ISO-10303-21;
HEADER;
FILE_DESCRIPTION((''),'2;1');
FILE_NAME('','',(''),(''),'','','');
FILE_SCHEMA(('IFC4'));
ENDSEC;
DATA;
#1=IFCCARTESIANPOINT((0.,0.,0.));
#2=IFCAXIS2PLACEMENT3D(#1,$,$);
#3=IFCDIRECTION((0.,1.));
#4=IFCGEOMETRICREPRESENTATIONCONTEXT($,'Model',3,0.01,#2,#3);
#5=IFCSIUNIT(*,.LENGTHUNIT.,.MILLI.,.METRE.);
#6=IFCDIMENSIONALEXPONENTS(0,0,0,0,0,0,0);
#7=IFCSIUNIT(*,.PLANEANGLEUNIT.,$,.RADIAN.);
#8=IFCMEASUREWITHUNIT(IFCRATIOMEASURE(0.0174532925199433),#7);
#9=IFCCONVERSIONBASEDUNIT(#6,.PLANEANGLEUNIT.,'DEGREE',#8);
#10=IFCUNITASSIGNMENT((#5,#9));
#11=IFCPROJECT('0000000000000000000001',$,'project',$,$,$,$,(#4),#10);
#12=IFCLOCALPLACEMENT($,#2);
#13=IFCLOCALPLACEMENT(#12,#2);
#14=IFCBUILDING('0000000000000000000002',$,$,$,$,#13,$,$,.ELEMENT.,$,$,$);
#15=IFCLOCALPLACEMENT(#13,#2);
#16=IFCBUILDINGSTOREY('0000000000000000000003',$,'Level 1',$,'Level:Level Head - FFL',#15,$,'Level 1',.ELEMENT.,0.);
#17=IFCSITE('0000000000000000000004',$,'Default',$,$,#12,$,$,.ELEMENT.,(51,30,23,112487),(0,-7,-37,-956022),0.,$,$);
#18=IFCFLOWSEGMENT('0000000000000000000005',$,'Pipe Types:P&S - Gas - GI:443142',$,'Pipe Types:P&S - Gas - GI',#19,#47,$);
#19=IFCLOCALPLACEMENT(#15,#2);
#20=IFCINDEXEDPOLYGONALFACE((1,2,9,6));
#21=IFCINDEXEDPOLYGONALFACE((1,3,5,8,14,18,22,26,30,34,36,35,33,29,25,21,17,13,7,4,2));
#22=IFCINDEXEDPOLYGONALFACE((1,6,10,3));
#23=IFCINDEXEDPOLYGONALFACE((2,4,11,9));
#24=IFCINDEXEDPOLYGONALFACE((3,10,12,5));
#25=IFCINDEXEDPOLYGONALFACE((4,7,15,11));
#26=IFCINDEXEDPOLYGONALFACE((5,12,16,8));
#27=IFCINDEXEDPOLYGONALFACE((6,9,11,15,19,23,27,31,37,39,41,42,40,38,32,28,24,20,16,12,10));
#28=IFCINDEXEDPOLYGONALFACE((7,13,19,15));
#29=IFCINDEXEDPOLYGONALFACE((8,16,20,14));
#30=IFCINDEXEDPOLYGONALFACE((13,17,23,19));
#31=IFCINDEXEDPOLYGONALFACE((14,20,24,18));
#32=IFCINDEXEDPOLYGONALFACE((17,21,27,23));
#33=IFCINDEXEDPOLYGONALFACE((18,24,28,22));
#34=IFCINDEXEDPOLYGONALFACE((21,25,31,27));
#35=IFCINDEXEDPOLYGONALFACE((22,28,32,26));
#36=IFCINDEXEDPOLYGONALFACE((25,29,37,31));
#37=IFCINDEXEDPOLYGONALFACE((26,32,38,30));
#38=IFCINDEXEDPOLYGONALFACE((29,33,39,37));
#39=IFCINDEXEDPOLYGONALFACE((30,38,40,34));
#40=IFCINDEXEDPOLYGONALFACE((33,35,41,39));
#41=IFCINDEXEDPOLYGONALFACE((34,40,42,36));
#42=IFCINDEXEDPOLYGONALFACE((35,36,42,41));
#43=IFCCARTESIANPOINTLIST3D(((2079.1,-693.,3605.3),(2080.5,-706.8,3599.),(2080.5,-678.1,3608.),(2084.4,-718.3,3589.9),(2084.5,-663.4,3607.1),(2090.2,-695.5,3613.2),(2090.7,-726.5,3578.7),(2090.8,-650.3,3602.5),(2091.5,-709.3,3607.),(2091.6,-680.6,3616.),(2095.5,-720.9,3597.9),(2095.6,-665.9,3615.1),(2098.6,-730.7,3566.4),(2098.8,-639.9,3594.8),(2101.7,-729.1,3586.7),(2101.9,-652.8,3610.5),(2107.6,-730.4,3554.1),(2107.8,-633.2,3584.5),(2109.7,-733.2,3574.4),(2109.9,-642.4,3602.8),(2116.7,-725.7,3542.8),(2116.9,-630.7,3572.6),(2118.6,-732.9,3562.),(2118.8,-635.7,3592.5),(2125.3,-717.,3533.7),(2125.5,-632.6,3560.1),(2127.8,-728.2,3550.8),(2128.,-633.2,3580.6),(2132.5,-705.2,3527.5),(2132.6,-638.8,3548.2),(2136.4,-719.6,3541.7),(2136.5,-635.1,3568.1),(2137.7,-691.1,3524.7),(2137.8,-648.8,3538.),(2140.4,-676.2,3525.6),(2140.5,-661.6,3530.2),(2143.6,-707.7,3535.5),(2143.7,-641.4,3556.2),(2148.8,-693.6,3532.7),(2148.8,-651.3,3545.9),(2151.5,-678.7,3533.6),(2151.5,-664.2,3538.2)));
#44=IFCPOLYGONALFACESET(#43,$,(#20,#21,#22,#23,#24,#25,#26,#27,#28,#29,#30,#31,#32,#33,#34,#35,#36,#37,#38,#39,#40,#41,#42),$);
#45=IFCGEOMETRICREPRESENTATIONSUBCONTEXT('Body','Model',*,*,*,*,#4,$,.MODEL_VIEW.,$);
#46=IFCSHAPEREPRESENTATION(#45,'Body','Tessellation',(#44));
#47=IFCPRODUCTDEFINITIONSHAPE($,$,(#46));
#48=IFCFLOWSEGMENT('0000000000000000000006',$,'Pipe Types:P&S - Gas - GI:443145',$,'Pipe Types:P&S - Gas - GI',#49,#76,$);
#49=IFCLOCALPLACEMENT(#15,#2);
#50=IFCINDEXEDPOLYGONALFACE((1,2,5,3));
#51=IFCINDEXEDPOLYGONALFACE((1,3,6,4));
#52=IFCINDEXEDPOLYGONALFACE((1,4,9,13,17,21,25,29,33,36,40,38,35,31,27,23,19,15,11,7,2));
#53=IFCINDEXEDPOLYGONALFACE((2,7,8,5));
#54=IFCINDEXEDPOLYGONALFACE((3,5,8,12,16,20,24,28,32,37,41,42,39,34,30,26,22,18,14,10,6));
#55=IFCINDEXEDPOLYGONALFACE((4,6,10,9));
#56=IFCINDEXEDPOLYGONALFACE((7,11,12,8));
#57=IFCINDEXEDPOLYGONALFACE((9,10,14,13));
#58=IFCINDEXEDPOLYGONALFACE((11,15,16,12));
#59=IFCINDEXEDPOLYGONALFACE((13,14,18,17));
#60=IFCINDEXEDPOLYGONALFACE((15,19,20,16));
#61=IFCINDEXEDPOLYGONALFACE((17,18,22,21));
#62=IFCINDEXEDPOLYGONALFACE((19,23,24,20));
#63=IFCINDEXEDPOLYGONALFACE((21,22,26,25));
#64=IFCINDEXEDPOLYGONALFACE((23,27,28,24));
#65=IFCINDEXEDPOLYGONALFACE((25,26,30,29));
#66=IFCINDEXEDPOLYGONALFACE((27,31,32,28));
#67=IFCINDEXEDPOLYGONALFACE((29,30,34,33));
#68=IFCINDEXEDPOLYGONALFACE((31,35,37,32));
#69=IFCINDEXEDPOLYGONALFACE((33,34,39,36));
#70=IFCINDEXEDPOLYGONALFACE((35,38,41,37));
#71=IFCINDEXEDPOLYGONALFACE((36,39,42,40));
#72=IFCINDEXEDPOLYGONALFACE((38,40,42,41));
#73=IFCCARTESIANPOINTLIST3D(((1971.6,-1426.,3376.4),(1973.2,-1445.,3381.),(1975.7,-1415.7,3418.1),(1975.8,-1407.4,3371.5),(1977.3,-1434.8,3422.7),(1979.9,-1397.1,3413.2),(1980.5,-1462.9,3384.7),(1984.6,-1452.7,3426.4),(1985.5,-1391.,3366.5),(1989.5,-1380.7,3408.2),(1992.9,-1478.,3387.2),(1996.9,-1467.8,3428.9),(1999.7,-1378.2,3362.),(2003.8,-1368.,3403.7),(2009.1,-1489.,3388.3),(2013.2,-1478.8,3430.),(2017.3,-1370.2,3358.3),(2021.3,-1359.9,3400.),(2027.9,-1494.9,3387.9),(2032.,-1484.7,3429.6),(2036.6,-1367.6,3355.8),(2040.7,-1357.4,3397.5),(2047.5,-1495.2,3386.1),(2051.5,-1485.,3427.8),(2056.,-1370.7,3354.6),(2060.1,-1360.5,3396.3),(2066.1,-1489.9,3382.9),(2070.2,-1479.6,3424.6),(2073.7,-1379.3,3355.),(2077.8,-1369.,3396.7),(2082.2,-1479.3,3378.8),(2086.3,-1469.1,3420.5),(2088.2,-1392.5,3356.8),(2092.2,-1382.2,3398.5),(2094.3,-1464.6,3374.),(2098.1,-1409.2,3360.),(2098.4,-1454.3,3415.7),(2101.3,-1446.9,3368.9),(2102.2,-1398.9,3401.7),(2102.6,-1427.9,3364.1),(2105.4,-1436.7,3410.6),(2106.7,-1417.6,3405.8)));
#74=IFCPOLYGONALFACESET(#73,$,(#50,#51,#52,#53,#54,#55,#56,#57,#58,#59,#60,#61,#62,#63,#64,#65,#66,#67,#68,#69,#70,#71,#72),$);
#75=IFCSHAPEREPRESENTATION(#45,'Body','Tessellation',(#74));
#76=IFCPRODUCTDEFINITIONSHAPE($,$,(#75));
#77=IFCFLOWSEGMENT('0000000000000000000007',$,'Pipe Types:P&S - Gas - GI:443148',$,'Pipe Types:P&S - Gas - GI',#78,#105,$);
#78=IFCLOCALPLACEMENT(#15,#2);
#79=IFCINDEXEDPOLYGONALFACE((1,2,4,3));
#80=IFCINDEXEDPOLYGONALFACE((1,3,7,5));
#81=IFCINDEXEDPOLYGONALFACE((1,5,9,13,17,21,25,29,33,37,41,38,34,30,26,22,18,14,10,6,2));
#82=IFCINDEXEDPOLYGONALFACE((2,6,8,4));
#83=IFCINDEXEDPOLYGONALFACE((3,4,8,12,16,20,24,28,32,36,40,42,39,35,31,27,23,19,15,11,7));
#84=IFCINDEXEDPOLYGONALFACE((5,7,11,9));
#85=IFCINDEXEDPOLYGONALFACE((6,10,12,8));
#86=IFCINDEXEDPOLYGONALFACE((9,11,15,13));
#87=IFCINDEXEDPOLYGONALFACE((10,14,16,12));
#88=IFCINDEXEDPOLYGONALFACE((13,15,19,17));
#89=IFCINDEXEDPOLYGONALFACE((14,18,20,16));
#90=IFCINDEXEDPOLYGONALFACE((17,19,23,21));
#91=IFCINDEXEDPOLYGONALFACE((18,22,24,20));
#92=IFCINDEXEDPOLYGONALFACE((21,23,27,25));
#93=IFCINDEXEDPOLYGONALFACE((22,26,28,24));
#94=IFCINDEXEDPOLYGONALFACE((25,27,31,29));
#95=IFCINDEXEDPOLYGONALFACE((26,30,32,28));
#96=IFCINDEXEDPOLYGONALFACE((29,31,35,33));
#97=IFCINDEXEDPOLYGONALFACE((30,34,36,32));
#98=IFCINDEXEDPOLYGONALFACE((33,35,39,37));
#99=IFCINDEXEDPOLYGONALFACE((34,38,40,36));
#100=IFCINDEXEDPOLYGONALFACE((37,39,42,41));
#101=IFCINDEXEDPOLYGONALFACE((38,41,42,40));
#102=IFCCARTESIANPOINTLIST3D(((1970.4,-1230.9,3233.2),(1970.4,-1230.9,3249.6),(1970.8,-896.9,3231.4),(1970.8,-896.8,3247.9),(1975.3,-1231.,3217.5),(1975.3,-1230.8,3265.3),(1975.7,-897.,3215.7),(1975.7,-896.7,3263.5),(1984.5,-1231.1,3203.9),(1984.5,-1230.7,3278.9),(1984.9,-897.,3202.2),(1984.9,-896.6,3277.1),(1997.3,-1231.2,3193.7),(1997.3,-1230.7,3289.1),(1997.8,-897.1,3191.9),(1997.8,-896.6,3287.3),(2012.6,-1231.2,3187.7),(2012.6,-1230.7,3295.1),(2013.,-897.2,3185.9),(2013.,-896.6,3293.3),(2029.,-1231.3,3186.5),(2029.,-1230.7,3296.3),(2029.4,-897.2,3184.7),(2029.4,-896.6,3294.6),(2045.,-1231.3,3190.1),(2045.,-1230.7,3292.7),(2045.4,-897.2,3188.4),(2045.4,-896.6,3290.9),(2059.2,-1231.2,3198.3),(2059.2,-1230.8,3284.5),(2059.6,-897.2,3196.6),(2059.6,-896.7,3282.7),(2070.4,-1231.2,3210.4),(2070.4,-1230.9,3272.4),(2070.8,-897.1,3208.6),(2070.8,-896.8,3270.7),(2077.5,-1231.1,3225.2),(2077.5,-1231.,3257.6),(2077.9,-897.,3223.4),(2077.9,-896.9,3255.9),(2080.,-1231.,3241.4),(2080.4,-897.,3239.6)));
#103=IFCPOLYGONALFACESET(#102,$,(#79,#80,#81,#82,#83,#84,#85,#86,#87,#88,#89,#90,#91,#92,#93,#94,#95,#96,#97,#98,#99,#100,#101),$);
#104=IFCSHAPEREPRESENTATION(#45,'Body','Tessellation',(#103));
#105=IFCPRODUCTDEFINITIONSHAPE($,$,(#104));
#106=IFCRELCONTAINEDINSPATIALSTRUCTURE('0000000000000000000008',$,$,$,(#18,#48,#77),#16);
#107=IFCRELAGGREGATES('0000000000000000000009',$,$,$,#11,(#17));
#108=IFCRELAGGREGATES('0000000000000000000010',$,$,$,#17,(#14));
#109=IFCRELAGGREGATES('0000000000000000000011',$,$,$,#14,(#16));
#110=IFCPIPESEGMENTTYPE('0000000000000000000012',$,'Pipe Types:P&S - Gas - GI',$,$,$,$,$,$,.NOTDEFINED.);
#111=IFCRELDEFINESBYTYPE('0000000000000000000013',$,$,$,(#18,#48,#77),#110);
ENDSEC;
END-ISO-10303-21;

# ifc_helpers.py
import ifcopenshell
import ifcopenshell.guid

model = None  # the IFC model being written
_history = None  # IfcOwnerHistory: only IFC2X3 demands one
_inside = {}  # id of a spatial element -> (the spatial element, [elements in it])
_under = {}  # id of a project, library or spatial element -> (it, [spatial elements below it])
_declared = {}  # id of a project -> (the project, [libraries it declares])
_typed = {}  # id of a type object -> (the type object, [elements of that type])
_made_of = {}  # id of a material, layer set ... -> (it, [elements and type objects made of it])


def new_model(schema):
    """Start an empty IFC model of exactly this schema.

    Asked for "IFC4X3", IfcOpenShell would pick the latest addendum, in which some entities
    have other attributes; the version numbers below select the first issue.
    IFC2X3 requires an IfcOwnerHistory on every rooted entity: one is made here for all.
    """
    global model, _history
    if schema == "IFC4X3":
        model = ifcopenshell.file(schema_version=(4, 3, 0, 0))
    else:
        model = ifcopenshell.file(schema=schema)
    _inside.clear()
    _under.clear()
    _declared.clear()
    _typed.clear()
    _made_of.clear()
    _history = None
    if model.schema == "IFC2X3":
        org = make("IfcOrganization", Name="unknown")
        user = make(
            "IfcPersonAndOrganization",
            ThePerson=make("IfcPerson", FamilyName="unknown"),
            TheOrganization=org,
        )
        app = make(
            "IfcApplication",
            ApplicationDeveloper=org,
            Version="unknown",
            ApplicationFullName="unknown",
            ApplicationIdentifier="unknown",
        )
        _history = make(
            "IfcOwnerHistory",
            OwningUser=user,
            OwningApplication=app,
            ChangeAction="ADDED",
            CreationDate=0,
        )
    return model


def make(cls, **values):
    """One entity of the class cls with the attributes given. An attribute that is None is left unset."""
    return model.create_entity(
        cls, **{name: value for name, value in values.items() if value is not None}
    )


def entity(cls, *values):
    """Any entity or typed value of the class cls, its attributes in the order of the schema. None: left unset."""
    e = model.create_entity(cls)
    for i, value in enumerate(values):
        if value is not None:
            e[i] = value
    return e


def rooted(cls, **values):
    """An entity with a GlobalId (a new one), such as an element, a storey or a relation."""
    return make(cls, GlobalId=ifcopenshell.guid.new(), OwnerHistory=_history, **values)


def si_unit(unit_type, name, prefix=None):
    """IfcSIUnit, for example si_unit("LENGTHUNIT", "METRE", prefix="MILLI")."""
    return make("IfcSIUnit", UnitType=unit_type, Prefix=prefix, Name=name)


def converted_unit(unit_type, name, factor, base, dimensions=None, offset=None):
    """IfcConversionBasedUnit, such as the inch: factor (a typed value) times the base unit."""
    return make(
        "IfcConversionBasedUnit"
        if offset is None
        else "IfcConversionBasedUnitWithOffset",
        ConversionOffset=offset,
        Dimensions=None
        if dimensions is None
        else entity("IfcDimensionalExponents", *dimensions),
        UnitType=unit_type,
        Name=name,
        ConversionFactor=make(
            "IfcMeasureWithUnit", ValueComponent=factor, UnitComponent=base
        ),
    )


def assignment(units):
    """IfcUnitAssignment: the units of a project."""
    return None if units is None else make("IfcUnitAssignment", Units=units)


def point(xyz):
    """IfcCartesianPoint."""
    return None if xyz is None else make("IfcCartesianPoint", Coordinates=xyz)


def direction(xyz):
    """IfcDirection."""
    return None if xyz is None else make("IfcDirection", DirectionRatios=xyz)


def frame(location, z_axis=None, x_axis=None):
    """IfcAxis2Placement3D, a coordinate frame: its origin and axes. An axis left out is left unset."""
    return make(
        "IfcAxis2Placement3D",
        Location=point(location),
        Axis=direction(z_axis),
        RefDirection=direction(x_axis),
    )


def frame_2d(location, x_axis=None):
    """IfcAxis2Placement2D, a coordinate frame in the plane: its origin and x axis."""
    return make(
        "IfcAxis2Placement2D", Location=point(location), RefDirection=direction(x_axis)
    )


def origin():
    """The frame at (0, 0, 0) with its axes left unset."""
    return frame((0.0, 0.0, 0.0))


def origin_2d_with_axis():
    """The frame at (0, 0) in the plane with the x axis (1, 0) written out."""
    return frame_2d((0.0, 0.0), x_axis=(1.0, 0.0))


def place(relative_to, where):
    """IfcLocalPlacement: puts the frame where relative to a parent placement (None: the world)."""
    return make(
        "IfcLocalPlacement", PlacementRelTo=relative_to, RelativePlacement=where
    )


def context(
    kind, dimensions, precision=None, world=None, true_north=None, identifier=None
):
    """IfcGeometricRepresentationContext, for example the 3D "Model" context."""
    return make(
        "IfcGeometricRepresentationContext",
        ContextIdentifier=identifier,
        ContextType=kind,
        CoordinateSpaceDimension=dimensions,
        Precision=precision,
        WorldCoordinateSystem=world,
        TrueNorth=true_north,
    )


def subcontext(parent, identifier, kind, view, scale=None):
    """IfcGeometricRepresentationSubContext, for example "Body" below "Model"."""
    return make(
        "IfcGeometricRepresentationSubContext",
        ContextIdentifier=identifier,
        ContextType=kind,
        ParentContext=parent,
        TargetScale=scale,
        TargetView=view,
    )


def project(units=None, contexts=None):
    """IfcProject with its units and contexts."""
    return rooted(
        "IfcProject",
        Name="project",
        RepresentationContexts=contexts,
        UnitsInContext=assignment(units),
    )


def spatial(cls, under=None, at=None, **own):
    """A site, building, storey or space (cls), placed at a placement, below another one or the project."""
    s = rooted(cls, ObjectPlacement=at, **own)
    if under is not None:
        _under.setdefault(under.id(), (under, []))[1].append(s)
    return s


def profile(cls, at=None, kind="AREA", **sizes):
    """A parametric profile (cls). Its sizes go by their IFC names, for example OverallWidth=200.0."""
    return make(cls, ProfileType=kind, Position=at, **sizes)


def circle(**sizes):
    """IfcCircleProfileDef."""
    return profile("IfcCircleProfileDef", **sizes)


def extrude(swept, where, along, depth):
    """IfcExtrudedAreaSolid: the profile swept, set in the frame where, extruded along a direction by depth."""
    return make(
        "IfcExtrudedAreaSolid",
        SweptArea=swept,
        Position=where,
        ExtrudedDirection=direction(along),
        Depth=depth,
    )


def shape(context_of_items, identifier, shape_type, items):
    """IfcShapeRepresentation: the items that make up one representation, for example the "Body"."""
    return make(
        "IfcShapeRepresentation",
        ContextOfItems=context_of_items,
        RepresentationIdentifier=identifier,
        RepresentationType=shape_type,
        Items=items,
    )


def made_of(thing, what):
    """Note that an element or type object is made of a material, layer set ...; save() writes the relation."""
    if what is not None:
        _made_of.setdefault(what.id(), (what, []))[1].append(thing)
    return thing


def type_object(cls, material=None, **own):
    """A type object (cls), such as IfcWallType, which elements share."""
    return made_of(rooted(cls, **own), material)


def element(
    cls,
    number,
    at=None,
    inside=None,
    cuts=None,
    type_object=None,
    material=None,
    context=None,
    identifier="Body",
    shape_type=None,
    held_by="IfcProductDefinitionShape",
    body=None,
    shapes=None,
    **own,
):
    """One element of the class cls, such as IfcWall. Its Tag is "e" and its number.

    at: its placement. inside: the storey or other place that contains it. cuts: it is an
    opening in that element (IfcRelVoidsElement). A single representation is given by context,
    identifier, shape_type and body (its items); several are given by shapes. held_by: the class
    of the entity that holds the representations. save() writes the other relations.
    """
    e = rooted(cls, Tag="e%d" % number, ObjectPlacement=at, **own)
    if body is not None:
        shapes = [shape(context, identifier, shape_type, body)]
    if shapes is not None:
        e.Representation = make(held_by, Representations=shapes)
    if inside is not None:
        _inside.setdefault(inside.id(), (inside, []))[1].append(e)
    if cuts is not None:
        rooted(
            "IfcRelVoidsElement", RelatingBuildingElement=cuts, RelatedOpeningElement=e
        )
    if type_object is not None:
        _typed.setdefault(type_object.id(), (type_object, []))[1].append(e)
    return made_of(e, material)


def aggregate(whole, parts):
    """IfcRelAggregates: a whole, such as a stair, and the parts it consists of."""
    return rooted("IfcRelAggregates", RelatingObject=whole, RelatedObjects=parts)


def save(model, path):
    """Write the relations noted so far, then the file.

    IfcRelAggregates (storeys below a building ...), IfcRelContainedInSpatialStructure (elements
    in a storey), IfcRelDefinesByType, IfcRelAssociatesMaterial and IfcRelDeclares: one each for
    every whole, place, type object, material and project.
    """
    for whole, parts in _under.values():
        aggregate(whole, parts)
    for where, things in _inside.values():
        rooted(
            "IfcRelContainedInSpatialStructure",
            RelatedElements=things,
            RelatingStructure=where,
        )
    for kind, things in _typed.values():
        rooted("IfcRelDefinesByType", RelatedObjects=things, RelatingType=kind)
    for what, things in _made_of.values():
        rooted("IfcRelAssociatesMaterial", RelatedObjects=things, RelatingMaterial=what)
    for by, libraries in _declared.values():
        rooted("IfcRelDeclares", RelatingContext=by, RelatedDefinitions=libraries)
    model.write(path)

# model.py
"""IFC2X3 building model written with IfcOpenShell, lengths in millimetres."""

from ifc_helpers import new_model, entity, si_unit, converted_unit, direction, frame, frame_2d, origin, origin_2d_with_axis, place, context, subcontext, project, spatial, circle, extrude, type_object, element, save


model = new_model("IFC2X3")

# Units and contexts
model_context = context("Model", 3, precision=0.01, world=origin(), true_north=direction((0.0, 1.0)))
body_context = subcontext(model_context, "Body", "Model", "MODEL_VIEW")
ifc_project = project(units=[si_unit("LENGTHUNIT", "METRE", prefix="MILLI"), converted_unit("PLANEANGLEUNIT", "DEGREE", entity("IfcRatioMeasure", 0.0174532925199433), si_unit("PLANEANGLEUNIT", "RADIAN"), dimensions=[0, 0, 0, 0, 0, 0, 0])], contexts=[model_context])

# Site, building, storey
site_placement = place(None, origin())
site = spatial("IfcSite", under=ifc_project, at=site_placement, Name="Default", CompositionType="ELEMENT", RefLatitude=(51, 30, 23, 112487), RefLongitude=(0, -7, -37, -956022), RefElevation=0.0)
building_placement = place(site_placement, origin())
building = spatial("IfcBuilding", under=site, at=building_placement, CompositionType="ELEMENT")
storey_placement = place(building_placement, origin())
storey = spatial("IfcBuildingStorey", under=building, at=storey_placement, Name="Level 1", ObjectType="Level:Level Head - FFL", LongName="Level 1", CompositionType="ELEMENT", Elevation=0.0)

# Flow segments
pipe_segment_type = type_object("IfcPipeSegmentType", Name="Pipe Types:P&S - Gas - GI", PredefinedType="NOTDEFINED")
flow_segment_1_placement = place(storey_placement, origin())
element("IfcFlowSegment", 1, at=flow_segment_1_placement, inside=storey, type_object=pipe_segment_type, Name="Pipe Types:P&S - Gas - GI:443142", ObjectType="Pipe Types:P&S - Gas - GI", context=body_context, shape_type="SweptSolid", body=[
    extrude(circle(Radius=51.1, at=frame_2d((0.0, 0.0), x_axis=(1.0, 0.0))), frame((2121.0, -683.4, 3574.4), z_axis=(-0.797295, 0.181707, -0.57559), x_axis=(-0.222206, -0.975, 0.0)), (0.0, 0.0, 1.0), 13.9),
])
flow_segment_2_placement = place(storey_placement, origin())
element("IfcFlowSegment", 2, at=flow_segment_2_placement, inside=storey, type_object=pipe_segment_type, Name="Pipe Types:P&S - Gas - GI:443145", ObjectType="Pipe Types:P&S - Gas - GI", context=body_context, shape_type="SweptSolid", body=[
    extrude(circle(Radius=66.0, at=origin_2d_with_axis()), frame((2037.1, -1431.7, 3371.5), z_axis=(0.094205, 0.237737, 0.966751), x_axis=(-0.929672, 0.368388, 0.0)), (0.0, 0.0, 1.0), 43.1),
])
flow_segment_3_placement = place(storey_placement, origin())
element("IfcFlowSegment", 3, at=flow_segment_3_placement, inside=storey, type_object=pipe_segment_type, Name="Pipe Types:P&S - Gas - GI:443148", ObjectType="Pipe Types:P&S - Gas - GI", context=body_context, shape_type="SweptSolid", body=[
    extrude(circle(Radius=55.1, at=origin_2d_with_axis()), frame((2025.3, -896.9, 3239.6), z_axis=(-0.001239, -0.999985, 0.005248), x_axis=(0.999999, -0.001239, 0.0)), (0.0, 0.0, 1.0), 334.1),
])

save(model, "model.ifc")
